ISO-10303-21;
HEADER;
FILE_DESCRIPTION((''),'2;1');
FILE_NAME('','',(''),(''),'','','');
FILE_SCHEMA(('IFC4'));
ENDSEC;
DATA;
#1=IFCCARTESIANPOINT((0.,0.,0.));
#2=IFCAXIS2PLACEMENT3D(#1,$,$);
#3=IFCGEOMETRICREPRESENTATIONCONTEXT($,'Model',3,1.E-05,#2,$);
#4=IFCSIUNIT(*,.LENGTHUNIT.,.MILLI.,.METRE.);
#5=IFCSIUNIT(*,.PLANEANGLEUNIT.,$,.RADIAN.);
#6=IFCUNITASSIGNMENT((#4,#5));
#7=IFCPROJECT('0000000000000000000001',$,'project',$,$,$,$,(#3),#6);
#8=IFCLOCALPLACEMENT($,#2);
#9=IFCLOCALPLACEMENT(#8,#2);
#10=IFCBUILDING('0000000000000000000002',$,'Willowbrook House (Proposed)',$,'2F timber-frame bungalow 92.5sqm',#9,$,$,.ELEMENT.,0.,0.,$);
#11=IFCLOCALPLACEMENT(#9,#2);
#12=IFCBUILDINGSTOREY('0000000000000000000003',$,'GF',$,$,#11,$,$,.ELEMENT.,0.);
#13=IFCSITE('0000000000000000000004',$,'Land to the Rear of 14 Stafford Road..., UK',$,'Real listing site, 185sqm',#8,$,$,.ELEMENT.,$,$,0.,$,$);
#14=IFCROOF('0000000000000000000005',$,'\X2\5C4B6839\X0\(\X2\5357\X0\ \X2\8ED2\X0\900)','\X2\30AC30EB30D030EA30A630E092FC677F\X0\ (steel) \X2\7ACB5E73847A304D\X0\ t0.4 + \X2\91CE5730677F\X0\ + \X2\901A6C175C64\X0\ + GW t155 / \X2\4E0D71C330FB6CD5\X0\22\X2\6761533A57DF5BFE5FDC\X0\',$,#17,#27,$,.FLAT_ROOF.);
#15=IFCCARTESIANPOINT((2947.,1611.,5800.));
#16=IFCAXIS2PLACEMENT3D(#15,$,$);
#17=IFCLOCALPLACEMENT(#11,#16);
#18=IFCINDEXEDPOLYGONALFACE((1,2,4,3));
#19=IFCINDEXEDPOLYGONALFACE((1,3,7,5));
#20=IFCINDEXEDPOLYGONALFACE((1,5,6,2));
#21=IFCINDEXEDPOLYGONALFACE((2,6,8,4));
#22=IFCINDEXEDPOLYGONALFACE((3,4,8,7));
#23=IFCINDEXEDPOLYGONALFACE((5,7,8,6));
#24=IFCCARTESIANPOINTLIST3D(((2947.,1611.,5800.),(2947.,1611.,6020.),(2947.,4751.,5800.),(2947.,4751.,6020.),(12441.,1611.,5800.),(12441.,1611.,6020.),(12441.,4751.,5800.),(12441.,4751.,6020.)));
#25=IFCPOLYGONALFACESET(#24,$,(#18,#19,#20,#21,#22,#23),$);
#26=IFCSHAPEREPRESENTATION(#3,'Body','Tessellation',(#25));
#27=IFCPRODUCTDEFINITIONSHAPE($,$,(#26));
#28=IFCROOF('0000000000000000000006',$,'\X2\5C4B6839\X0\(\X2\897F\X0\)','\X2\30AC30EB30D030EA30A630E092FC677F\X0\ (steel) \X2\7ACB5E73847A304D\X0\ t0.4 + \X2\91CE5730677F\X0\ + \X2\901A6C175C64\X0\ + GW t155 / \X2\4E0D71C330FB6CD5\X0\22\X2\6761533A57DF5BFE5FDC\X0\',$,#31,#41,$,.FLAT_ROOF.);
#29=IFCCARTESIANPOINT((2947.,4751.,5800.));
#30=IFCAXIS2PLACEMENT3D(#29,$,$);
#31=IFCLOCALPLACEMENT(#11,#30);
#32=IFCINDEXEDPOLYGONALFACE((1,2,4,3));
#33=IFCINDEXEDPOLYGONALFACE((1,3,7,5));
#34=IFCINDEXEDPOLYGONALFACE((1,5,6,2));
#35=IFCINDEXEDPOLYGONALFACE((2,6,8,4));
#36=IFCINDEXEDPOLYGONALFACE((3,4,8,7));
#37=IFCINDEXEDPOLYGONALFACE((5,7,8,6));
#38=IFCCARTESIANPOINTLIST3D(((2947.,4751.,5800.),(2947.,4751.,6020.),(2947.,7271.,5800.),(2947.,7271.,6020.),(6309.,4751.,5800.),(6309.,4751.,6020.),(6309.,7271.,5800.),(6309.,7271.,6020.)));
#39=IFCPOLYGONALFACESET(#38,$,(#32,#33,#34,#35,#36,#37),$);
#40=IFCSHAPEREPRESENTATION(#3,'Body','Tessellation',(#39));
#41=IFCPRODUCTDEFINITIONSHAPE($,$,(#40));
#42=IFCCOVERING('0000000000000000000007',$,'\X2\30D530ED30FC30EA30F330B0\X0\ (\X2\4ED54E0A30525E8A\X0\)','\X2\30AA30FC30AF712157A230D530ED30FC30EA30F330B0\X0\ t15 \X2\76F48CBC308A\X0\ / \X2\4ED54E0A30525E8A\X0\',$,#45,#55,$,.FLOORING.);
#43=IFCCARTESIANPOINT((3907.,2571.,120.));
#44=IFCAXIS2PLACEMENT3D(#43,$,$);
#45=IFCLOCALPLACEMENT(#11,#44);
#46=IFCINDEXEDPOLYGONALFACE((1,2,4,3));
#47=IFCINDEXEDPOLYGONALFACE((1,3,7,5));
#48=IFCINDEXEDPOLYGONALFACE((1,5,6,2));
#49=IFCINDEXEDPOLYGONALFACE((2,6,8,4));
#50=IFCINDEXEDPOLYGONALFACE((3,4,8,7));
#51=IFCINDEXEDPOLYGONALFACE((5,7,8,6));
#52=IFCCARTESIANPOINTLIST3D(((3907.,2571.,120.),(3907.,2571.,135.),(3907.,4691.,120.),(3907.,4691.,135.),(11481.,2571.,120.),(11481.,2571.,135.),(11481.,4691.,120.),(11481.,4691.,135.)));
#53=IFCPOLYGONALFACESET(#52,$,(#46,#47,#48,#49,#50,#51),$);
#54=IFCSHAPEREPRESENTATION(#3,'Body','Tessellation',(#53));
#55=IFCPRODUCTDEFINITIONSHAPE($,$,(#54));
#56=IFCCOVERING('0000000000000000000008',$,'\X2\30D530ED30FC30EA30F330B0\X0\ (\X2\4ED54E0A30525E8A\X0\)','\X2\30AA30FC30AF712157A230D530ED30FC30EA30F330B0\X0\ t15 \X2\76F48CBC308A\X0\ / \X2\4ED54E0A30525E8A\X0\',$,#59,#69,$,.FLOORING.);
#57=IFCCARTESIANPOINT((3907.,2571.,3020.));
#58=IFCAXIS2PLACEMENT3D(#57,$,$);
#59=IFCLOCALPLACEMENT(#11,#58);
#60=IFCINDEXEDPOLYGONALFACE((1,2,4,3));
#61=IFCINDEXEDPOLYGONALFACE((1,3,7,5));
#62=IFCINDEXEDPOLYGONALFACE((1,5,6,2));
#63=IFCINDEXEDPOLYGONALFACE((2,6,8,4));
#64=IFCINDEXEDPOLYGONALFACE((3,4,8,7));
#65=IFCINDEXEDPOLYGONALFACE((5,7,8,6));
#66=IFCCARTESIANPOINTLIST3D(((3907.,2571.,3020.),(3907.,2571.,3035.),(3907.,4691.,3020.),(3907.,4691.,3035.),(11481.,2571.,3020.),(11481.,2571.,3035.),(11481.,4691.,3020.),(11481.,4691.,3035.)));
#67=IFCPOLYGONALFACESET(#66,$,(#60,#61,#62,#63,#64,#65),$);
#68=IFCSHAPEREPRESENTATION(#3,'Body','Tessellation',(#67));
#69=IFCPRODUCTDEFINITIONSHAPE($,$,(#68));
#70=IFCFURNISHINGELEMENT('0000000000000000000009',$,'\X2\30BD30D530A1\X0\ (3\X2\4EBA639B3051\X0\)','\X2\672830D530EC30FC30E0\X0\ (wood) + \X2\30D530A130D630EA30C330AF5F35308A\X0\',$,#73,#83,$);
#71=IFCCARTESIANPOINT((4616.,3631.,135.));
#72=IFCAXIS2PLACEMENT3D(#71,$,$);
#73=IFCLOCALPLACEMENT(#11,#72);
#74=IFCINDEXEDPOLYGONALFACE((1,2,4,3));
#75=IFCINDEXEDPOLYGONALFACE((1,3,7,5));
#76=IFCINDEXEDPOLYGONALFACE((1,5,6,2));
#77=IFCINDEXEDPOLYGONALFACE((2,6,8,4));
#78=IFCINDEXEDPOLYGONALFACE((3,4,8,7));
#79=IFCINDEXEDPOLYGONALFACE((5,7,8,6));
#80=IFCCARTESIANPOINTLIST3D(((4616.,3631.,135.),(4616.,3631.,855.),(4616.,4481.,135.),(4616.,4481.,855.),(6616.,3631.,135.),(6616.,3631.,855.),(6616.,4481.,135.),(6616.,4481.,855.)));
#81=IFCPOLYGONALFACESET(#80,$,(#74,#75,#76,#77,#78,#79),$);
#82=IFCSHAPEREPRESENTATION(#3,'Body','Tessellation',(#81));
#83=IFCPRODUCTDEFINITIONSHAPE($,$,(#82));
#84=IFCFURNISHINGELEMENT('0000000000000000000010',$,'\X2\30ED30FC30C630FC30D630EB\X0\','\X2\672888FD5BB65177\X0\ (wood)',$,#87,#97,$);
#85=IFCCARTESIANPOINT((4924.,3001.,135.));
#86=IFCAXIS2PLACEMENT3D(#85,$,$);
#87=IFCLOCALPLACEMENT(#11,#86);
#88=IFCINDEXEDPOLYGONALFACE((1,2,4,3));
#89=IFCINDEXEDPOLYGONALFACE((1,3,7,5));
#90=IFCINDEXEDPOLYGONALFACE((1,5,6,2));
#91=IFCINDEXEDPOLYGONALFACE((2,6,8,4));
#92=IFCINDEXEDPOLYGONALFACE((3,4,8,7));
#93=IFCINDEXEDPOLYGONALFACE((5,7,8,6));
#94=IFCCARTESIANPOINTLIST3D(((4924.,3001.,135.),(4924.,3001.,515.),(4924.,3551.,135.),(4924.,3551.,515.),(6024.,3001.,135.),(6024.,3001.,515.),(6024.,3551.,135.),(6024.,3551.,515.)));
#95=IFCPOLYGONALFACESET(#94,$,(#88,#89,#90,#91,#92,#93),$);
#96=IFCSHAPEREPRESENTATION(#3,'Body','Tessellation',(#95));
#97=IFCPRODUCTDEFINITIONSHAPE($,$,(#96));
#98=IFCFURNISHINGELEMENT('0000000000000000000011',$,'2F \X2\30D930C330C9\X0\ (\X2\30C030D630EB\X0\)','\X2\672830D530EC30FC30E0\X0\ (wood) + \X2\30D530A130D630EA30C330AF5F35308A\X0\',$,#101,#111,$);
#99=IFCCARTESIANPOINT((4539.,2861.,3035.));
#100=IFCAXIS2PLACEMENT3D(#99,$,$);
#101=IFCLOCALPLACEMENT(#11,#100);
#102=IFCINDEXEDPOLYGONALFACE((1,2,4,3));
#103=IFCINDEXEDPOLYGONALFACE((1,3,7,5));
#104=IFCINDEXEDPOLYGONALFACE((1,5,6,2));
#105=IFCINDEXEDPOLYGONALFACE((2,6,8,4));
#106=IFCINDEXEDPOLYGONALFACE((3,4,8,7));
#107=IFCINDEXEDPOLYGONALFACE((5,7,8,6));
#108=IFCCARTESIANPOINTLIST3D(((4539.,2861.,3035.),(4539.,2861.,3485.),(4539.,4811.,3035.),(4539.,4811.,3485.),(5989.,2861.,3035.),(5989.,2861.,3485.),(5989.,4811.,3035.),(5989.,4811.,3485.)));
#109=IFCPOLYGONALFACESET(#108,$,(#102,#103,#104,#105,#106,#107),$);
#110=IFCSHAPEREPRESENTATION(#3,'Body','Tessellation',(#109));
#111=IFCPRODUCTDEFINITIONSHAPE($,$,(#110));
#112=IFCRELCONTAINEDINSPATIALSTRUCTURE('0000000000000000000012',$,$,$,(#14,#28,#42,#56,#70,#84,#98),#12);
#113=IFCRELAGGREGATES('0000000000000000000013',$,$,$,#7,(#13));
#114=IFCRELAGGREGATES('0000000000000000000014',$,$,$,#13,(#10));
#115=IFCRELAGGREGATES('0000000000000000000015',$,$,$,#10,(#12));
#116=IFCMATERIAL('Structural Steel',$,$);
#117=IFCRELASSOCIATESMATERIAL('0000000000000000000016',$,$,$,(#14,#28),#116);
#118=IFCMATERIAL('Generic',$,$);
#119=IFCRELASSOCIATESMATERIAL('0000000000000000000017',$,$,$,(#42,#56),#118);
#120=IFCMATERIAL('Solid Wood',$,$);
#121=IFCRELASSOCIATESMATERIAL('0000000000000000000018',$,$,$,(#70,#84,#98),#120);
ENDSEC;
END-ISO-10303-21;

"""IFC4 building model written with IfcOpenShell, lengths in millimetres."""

from ifc_helpers import new_model, si_unit, frame, frame_2d, origin, place, context, project, spatial, rectangle, extrude, material, element, save


model = new_model("IFC4")

# Units and contexts
model_context = context("Model", 3, precision=1e-05, world=origin())
ifc_project = project(units=[si_unit("LENGTHUNIT", "METRE", prefix="MILLI"), si_unit("PLANEANGLEUNIT", "RADIAN")], contexts=[model_context])

# Site, building, storey
site_placement = place(None, origin())
site = spatial("IfcSite", under=ifc_project, at=site_placement, Name="Land to the Rear of 14 Stafford Road..., UK", ObjectType="Real listing site, 185sqm", CompositionType="ELEMENT", RefElevation=0.0)
building_placement = place(site_placement, origin())
building = spatial("IfcBuilding", under=site, at=building_placement, Name="Willowbrook House (Proposed)", ObjectType="2F timber-frame bungalow 92.5sqm", CompositionType="ELEMENT", ElevationOfRefHeight=0.0, ElevationOfTerrain=0.0)
storey_placement = place(building_placement, origin())
storey = spatial("IfcBuildingStorey", under=building, at=storey_placement, Name="GF", CompositionType="ELEMENT", Elevation=0.0)

# Shared definitions
ifc_material_1 = material(Name="Solid Wood")

# Roofs
ifc_material_2 = material(Name="Structural Steel")
roof_1_placement = place(storey_placement, frame((2947.0, 1611.0, 5800.0)))
element("IfcRoof", 1, at=roof_1_placement, inside=storey, material=ifc_material_2, Name="屋根(南 軒900)", Description="ガルバリウム鋼板 (steel) 立平葺き t0.4 + 野地板 + 通気層 + GW t155 / 不燃・法22条区域対応", PredefinedType="FLAT_ROOF", context=model_context, shape_type="SweptSolid", body=[
    extrude(rectangle(XDim=9494.0, YDim=3140.0, at=frame_2d((4747.0, 1570.0))), frame((2947.0, 1611.0, 5800.0)), (0.0, 0.0, 1.0), 220.0),
])
roof_2_placement = place(storey_placement, frame((2947.0, 4751.0, 5800.0)))
element("IfcRoof", 2, at=roof_2_placement, inside=storey, material=ifc_material_2, Name="屋根(西)", Description="ガルバリウム鋼板 (steel) 立平葺き t0.4 + 野地板 + 通気層 + GW t155 / 不燃・法22条区域対応", PredefinedType="FLAT_ROOF", context=model_context, shape_type="SweptSolid", body=[
    extrude(rectangle(XDim=3362.0, YDim=2520.0, at=frame_2d((1681.0, 1260.0))), frame((2947.0, 4751.0, 5800.0)), (0.0, 0.0, 1.0), 220.0),
])

# Coverings
ifc_material_3 = material(Name="Generic")
covering_1_placement = place(storey_placement, frame((3907.0, 2571.0, 120.0)))
element("IfcCovering", 3, at=covering_1_placement, inside=storey, material=ifc_material_3, Name="フローリング (仕上げ床)", Description="オーク無垢フローリング t15 直貼り / 仕上げ床", PredefinedType="FLOORING", context=model_context, shape_type="SweptSolid", body=[
    extrude(rectangle(XDim=7574.0, YDim=2120.0, at=frame_2d((3787.0, 1060.0))), frame((3907.0, 2571.0, 120.0)), (0.0, 0.0, 1.0), 15.0),
])
covering_2_placement = place(storey_placement, frame((3907.0, 2571.0, 3020.0)))
element("IfcCovering", 4, at=covering_2_placement, inside=storey, material=ifc_material_3, Name="フローリング (仕上げ床)", Description="オーク無垢フローリング t15 直貼り / 仕上げ床", PredefinedType="FLOORING", context=model_context, shape_type="SweptSolid", body=[
    extrude(rectangle(XDim=7574.0, YDim=2120.0, at=frame_2d((3787.0, 1060.0))), frame((3907.0, 2571.0, 3020.0)), (0.0, 0.0, 1.0), 15.0),
])

# Furnishing elements
furnishing_1_placement = place(storey_placement, frame((4616.0, 3631.0, 135.0)))
element("IfcFurnishingElement", 5, at=furnishing_1_placement, inside=storey, material=ifc_material_1, Name="ソファ (3人掛け)", Description="木フレーム (wood) + ファブリック張り", context=model_context, shape_type="SweptSolid", body=[
    extrude(rectangle(XDim=2000.0, YDim=850.0, at=frame_2d((1000.0, 425.0))), frame((4616.0, 3631.0, 135.0)), (0.0, 0.0, 1.0), 720.0),
])
furnishing_2_placement = place(storey_placement, frame((4924.0, 3001.0, 135.0)))
element("IfcFurnishingElement", 6, at=furnishing_2_placement, inside=storey, material=ifc_material_1, Name="ローテーブル", Description="木製家具 (wood)", context=model_context, shape_type="SweptSolid", body=[
    extrude(rectangle(XDim=1100.0, YDim=550.0, at=frame_2d((550.0, 275.0))), frame((4924.0, 3001.0, 135.0)), (0.0, 0.0, 1.0), 380.0),
])
furnishing_3_placement = place(storey_placement, frame((4539.0, 2861.0, 3035.0)))
element("IfcFurnishingElement", 7, at=furnishing_3_placement, inside=storey, material=ifc_material_1, Name="2F ベッド (ダブル)", Description="木フレーム (wood) + ファブリック張り", context=model_context, shape_type="SweptSolid", body=[
    extrude(rectangle(XDim=1450.0, YDim=1950.0, at=frame_2d((725.0, 975.0))), frame((4539.0, 2861.0, 3035.0)), (0.0, 0.0, 1.0), 450.0),
])

save(model, "model.ifc")
